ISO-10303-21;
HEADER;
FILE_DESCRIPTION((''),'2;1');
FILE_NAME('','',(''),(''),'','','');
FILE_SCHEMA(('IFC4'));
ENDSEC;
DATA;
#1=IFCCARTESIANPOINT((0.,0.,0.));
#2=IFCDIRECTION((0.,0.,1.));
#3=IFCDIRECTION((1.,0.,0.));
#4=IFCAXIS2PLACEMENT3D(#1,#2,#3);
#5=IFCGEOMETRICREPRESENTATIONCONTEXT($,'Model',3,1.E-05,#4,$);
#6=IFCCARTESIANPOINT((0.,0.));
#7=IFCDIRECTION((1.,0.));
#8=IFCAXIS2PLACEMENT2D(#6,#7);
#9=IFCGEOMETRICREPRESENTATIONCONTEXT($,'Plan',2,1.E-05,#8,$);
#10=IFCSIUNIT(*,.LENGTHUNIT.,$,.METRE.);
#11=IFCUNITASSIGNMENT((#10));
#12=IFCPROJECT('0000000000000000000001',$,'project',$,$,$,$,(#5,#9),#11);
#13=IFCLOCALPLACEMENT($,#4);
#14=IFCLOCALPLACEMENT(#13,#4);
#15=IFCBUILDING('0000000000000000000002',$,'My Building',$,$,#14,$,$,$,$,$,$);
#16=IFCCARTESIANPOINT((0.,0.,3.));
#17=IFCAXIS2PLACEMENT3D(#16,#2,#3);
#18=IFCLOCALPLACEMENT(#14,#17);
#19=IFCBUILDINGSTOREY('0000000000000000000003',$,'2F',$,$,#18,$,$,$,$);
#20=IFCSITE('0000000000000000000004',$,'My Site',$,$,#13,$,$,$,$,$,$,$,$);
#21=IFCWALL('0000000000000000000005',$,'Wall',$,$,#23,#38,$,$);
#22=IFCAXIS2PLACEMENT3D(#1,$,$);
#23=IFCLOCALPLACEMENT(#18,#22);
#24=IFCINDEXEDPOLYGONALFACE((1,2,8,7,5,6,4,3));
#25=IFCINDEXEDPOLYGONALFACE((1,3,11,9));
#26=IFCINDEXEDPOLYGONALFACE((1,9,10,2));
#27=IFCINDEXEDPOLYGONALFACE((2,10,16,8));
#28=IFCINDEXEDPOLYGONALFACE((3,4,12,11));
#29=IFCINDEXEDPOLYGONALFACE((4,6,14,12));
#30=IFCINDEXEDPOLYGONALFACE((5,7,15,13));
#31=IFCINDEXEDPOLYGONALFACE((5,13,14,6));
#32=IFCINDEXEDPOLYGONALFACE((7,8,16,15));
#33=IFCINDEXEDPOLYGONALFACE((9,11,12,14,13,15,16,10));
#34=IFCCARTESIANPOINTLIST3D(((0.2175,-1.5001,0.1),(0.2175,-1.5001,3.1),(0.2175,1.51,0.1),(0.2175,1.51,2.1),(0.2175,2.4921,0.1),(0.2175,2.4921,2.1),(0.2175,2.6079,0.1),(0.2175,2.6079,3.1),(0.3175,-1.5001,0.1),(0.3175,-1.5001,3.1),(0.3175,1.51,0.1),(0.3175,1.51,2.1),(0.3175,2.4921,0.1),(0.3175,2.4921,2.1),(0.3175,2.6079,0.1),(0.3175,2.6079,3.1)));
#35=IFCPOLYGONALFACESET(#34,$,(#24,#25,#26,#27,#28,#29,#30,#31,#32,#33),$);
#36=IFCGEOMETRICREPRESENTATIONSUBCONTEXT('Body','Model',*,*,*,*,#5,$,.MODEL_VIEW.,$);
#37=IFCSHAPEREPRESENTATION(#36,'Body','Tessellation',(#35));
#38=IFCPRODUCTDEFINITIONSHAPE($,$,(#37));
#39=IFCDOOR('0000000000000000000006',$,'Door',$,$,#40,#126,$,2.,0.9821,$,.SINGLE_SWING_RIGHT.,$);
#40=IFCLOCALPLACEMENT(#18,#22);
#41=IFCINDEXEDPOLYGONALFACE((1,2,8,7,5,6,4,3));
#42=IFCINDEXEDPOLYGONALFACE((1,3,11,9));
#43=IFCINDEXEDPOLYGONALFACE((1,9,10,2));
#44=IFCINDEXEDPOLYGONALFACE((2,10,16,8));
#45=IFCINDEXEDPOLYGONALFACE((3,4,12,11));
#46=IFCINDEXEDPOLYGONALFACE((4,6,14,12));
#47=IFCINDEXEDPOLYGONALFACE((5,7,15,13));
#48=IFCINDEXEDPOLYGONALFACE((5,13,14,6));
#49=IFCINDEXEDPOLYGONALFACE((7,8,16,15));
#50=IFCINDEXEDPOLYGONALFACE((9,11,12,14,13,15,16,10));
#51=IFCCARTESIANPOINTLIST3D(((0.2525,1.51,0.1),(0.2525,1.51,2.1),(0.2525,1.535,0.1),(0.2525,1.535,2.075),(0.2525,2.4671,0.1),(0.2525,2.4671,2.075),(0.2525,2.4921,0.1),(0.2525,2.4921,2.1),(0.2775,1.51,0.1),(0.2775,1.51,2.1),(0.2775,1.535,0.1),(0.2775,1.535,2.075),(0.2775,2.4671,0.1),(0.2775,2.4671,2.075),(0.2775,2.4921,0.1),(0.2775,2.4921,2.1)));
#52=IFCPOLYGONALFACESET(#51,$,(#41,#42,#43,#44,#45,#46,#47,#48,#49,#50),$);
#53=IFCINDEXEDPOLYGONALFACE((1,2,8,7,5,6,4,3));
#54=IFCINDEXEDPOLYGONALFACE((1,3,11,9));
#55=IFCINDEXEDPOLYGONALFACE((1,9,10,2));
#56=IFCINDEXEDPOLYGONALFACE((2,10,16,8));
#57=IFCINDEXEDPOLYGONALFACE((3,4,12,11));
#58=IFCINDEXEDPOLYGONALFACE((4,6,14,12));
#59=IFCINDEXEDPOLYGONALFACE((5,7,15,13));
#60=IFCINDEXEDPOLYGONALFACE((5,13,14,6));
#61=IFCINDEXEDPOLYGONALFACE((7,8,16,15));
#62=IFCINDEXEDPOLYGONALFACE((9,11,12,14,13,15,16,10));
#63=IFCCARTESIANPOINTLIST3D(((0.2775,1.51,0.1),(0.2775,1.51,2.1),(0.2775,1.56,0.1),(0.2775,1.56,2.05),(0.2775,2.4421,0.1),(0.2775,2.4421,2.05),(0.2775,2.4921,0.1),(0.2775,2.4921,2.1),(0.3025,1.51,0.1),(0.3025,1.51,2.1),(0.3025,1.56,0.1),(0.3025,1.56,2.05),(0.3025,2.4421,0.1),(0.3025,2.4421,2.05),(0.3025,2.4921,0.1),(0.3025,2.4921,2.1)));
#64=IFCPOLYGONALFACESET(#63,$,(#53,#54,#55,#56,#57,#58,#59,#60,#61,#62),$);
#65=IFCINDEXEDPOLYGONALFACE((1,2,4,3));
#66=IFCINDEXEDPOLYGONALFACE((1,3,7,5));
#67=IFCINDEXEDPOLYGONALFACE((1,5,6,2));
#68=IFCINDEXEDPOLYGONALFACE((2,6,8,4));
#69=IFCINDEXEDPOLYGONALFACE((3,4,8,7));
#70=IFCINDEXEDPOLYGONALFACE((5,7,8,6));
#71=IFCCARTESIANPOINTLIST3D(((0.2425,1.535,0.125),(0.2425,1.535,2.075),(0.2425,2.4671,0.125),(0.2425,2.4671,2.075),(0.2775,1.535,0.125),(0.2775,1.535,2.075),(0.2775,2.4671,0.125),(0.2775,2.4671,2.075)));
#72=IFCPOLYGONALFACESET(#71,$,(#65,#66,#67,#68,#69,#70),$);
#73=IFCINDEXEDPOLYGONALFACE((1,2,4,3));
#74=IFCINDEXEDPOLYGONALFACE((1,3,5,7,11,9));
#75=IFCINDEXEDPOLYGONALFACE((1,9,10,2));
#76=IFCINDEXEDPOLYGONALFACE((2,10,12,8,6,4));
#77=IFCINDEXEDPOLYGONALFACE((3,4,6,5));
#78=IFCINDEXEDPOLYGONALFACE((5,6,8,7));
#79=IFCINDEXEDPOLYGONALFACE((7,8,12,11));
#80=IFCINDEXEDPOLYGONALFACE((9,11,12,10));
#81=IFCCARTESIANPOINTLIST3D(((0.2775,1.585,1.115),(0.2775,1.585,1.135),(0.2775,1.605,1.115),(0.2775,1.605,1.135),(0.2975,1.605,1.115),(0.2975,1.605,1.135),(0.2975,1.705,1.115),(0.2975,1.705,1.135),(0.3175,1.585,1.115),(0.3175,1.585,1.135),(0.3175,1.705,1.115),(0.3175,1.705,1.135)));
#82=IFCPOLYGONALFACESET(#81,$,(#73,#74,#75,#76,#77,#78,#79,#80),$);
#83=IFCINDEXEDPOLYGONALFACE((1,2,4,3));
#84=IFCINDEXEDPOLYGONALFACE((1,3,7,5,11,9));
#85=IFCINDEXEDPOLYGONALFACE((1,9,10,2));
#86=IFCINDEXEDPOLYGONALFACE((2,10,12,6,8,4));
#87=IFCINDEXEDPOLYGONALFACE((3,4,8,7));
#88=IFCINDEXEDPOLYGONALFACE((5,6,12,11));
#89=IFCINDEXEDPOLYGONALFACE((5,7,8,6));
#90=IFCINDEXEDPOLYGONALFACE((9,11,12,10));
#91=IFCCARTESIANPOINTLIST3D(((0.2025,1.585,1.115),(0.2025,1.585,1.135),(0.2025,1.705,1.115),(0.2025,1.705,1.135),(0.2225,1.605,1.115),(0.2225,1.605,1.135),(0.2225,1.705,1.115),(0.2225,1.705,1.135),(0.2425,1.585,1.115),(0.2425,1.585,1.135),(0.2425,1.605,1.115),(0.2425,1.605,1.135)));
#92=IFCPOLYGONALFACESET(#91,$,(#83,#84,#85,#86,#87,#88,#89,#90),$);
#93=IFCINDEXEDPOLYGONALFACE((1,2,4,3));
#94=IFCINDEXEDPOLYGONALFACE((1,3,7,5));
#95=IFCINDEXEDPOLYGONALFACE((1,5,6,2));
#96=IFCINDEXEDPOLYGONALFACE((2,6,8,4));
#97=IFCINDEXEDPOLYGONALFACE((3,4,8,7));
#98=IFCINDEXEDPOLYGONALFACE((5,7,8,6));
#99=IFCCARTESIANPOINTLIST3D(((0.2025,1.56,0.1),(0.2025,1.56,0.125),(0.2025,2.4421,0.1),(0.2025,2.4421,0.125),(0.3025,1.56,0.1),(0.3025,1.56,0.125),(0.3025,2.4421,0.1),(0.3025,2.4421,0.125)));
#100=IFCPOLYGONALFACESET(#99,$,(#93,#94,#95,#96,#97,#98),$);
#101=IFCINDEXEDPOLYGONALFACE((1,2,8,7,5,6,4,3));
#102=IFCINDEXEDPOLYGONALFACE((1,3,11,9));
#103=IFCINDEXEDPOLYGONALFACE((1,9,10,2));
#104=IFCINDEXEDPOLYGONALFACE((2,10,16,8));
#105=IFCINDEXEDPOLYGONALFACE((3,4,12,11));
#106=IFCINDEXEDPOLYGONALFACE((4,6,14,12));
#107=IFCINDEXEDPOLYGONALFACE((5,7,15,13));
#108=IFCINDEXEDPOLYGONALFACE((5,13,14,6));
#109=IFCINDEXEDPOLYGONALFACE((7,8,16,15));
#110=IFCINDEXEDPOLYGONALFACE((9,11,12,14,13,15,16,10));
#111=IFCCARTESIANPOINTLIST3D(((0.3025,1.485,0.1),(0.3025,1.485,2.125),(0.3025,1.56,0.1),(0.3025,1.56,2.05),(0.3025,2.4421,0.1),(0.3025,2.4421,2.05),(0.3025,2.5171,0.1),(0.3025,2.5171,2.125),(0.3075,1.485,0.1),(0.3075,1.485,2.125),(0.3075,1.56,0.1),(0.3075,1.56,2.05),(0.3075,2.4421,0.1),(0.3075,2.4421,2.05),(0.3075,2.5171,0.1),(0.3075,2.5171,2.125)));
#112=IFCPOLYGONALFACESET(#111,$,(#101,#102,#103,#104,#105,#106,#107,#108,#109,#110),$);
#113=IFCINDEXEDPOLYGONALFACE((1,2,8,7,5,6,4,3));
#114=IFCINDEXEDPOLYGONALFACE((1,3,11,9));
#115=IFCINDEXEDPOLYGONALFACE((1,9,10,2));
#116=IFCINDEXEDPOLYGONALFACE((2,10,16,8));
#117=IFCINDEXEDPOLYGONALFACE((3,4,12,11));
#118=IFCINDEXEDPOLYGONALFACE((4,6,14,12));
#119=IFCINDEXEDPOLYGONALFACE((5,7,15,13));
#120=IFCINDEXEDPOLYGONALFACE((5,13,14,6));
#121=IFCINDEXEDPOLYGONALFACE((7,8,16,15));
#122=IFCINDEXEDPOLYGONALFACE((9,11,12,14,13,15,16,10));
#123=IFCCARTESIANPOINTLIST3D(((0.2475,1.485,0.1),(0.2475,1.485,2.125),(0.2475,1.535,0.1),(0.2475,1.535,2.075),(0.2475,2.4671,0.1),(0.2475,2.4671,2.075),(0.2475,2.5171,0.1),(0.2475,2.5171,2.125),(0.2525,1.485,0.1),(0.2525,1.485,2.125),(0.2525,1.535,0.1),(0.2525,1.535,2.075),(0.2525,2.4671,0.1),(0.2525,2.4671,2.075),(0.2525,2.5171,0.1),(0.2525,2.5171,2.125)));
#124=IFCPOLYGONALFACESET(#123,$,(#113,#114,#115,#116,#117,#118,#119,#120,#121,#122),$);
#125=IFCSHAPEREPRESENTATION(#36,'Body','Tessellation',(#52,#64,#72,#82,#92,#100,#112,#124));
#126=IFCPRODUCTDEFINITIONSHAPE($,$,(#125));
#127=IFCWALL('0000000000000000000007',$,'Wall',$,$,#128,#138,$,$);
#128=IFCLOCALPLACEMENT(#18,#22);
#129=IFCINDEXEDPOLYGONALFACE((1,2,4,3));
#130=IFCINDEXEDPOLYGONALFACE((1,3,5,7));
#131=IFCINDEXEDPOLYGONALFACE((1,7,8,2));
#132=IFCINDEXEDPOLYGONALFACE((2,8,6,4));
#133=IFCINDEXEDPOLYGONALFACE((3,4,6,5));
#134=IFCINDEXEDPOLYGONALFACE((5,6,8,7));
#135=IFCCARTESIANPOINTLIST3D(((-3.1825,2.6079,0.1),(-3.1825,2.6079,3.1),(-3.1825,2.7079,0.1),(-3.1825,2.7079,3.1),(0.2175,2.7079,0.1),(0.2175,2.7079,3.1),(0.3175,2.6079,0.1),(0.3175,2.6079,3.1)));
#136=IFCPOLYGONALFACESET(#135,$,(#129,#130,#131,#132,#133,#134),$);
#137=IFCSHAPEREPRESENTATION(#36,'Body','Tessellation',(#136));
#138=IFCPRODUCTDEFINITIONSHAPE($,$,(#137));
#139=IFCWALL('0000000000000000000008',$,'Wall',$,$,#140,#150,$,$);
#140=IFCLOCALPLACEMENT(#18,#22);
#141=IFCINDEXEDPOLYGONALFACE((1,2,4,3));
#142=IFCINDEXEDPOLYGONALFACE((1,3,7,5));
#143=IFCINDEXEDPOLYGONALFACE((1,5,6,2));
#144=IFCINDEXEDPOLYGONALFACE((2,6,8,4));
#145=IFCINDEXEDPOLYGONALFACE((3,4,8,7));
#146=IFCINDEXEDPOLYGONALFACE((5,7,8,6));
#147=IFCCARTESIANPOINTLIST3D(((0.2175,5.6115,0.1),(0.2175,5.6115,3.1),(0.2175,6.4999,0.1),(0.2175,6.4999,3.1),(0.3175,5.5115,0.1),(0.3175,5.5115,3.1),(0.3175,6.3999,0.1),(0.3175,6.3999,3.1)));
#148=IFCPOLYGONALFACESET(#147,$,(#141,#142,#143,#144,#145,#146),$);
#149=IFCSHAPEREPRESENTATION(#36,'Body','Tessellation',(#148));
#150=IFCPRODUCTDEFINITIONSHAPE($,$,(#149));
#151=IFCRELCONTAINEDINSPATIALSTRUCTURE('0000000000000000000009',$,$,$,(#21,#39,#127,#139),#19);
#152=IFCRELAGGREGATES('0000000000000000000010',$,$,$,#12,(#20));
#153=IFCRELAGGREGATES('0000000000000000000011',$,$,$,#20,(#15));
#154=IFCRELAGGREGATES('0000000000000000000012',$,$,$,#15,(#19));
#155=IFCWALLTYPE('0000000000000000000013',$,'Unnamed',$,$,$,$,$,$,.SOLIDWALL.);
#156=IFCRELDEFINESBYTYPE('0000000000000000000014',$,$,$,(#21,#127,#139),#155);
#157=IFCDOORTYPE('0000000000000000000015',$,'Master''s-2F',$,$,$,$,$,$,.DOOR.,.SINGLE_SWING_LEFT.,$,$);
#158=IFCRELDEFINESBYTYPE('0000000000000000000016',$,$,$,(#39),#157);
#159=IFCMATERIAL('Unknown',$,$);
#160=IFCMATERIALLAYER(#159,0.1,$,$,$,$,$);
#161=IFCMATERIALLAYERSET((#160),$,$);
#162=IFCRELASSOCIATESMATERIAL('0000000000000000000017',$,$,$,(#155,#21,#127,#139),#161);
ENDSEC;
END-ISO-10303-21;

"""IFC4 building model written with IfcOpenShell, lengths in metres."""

from ifc_helpers import new_model, entity, si_unit, frame, origin_with_axes, origin_2d_with_axis, place, context, subcontext, project, spatial, line, indexed_curve, outline, extrude, shape, source, transform, mapped, material, layer, layer_set, layer_usage, type_object, type_shapes, element, fill, save


model = new_model("IFC4")

# Units and contexts
model_context = context("Model", 3, precision=1e-05, world=origin_with_axes())
plan_context = context("Plan", 2, precision=1e-05, world=origin_2d_with_axis())
body_context_1 = subcontext(model_context, "Body", "Model", "MODEL_VIEW")
body_context_2 = subcontext(plan_context, "Body", "Plan", "PLAN_VIEW")
ifc_project = project(units=[si_unit("LENGTHUNIT", "METRE")], contexts=[model_context, plan_context])

# Site, building, storey
site_placement = place(None, origin_with_axes())
site = spatial("IfcSite", under=ifc_project, at=site_placement, Name="My Site")
building_placement = place(site_placement, origin_with_axes())
building = spatial("IfcBuilding", under=site, at=building_placement, Name="My Building")
storey_placement = place(building_placement, frame((0.0, 0.0, 3.0), z_axis=(0.0, 0.0, 1.0), x_axis=(1.0, 0.0, 0.0)))
storey = spatial("IfcBuildingStorey", under=building, at=storey_placement, Name="2F")

# Shared definitions
ifc_material = material(Name="Unknown")
ifc_layer = layer(ifc_material, 0.1)
ifc_layer_set = layer_set([ifc_layer])
wall_type = type_object("IfcWallType", Name="Unnamed", PredefinedType="SOLIDWALL", material=ifc_layer_set)

# Wall, opening, door
ifc_layer_usage_1 = layer_usage(ifc_layer_set, "AXIS2", "POSITIVE", 0.0)
wall_1_placement = place(storey_placement, frame((0.2175, 2.7079, 0.1), z_axis=(0.0, 0.0, 1.0), x_axis=(0.0, -1.0, 0.0)))
wall_1 = element("IfcWall", 1, at=wall_1_placement, inside=storey, type_object=wall_type, material=ifc_layer_usage_1, Name="Wall", context=body_context_1, shape_type="SweptSolid", body=[
    extrude(outline(indexed_curve([(0.1, 0.0), (0.1, 0.1), (4.2079, 0.1), (4.2079, 0.0)], segments=[line(1, 2, 3, 4, 1)])), origin_with_axes(), (0.0, 0.0, 1.0), 3.0),
])
shared_shape_1 = source(origin_with_axes(), body_context_1, "Body", "SweptSolid", [
    extrude(outline(indexed_curve([(0.0, 0.0), (0.9821, 0.0), (0.9821, 2.0), (0.0, 2.0)], segments=[line(1, 2, 3, 4, 1)])), frame((0.0, -0.6, 0.0), z_axis=(0.0, -1.0, 0.0), x_axis=(1.0, 0.0, 0.0)), (0.0, 0.0, -1.0), 1.2),
])
opening_1_placement = place(wall_1_placement, frame((1.1978, 0.085, 0.0), z_axis=(0.0, 0.0, 1.0), x_axis=(-1.0, 0.0, 0.0)))
opening_1 = element("IfcOpeningElement", 2, at=opening_1_placement, cuts=wall_1, PredefinedType="OPENING", context=body_context_1, shape_type="MappedRepresentation", body=[
    mapped(shared_shape_1, transform((0.0, 0.0, 0.0), x_axis=(1.0, 0.0, 0.0), y_axis=(0.0, 1.0, 0.0), z_axis=(0.0, 0.0, 1.0), scale=1.0)),
])
door_type_1 = type_object("IfcDoorType", Name="Master's-2F", OperationType="SINGLE_SWING_LEFT", PredefinedType="DOOR")
shared_shape_2 = source(origin_with_axes(), body_context_1, "Body", "SweptSolid", [
    extrude(outline(indexed_curve([(0.0, 0.0), (0.0, 2.0), (0.9821, 2.0), (0.9821, 0.0), (0.9571, 0.0), (0.9571, 1.975), (0.025, 1.975), (0.025, 0.0)], segments=[line(1, 2, 3, 4, 5, 6, 7, 8, 1)])), frame((0.0, 0.025, 0.0), z_axis=(0.0, -1.0, 0.0), x_axis=(1.0, 0.0, 0.0)), (0.0, 0.0, -1.0), 0.025),
    extrude(outline(indexed_curve([(0.0, 0.0), (0.0, 2.0), (0.9821, 2.0), (0.9821, 0.0), (0.9321, 0.0), (0.9321, 1.95), (0.05, 1.95), (0.05, 0.0)], segments=[line(1, 2, 3, 4, 5, 6, 7, 8, 1)])), frame((0.0, 0.0, 0.0), z_axis=(0.0, -1.0, 0.0), x_axis=(1.0, 0.0, 0.0)), (0.0, 0.0, -1.0), 0.025),
    extrude(outline(indexed_curve([(0.0, 0.0), (0.9321, 0.0), (0.9321, 0.035), (0.0, 0.035)], segments=[line(1, 2, 3, 4, 1)])), frame((0.025, 0.025, 0.025), z_axis=(0.0, 0.0, 1.0), x_axis=(1.0, 0.0, 0.0)), (0.0, 0.0, 1.0), 1.95),
    extrude(outline(indexed_curve([(0.0, 0.0), (0.0, -0.04), (0.12, -0.04), (0.12, -0.02), (0.02, -0.02), (0.02, 0.0)], segments=[line(1, 2, 3, 4, 5, 6, 1)])), frame((0.075, 0.025, 1.015), z_axis=(0.0, 0.0, 1.0), x_axis=(1.0, 0.0, 0.0)), (0.0, 0.0, 1.0), 0.02),
    extrude(outline(indexed_curve([(0.0, 0.0), (0.0, 0.04), (0.12, 0.04), (0.12, 0.02), (0.02, 0.02), (0.02, 0.0)], segments=[line(1, 2, 3, 4, 5, 6, 1)])), frame((0.075, 0.06, 1.015), z_axis=(0.0, 0.0, 1.0), x_axis=(1.0, 0.0, 0.0)), (0.0, 0.0, 1.0), 0.02),
    extrude(outline(indexed_curve([(0.0, 0.0), (0.8821, 0.0), (0.8821, 0.1), (0.0, 0.1)], segments=[line(1, 2, 3, 4, 1)])), frame((0.05, 0.0, 0.0), z_axis=(0.0, 0.0, 1.0), x_axis=(1.0, 0.0, 0.0)), (0.0, 0.0, 1.0), 0.025),
    extrude(outline(indexed_curve([(0.0, 0.0), (0.0, 2.025), (1.0321, 2.025), (1.0321, 0.0), (0.9571, 0.0), (0.9571, 1.95), (0.075, 1.95), (0.075, 0.0)], segments=[line(1, 2, 3, 4, 5, 6, 7, 8, 1)])), frame((-0.025, -0.005, 0.0), z_axis=(0.0, -1.0, 0.0), x_axis=(1.0, 0.0, 0.0)), (0.0, 0.0, -1.0), 0.005),
    extrude(outline(indexed_curve([(0.0, 0.0), (0.0, 2.025), (1.0321, 2.025), (1.0321, 0.0), (0.9821, 0.0), (0.9821, 1.975), (0.05, 1.975), (0.05, 0.0)], segments=[line(1, 2, 3, 4, 5, 6, 7, 8, 1)])), frame((-0.025, 0.05, 0.0), z_axis=(0.0, -1.0, 0.0), x_axis=(1.0, 0.0, 0.0)), (0.0, 0.0, -1.0), 0.005),
])
shared_shape_3 = source(origin_with_axes(), body_context_2, "Body", "Curve2D", [
    entity("IfcIndexedPolyCurve", entity("IfcCartesianPointList2D", [[0.0, 0.0], [0.0, 0.05], [0.025, 0.05], [0.025, 0.025], [0.05, 0.025], [0.05, 0.0]]), [entity("IfcLineIndex", [1, 2, 3, 4, 5, 6, 1])]),
    entity("IfcIndexedPolyCurve", entity("IfcCartesianPointList2D", [[0.9821, 0.0], [0.9821, 0.05], [0.9571, 0.05], [0.9571, 0.025], [0.9321, 0.025], [0.9321, 0.0]]), [entity("IfcLineIndex", [1, 2, 3, 4, 5, 6, 1])]),
    entity("IfcTrimmedCurve", entity("IfcEllipse", entity("IfcAxis2Placement2D", entity("IfcCartesianPoint", [0.9221, 0.05]), entity("IfcDirection", [1.0, 0.0])), 0.8971, 0.9321), [entity("IfcCartesianPoint", [0.9221, 0.9821])], [entity("IfcCartesianPoint", [0.025, 0.05])], True, "CARTESIAN"),
    entity("IfcIndexedPolyCurve", entity("IfcCartesianPointList2D", [[0.9571, 0.05], [0.9221, 0.05], [0.9221, 0.9821], [0.9571, 0.9821]]), [entity("IfcLineIndex", [1, 2, 3, 4, 1])]),
])
type_shapes(door_type_1, [shared_shape_2, shared_shape_3])
door_1_placement = place(opening_1_placement, frame((0.0, 0.0, 0.0), z_axis=(0.0, 0.0, 1.0), x_axis=(1.0, 0.0, 0.0)))
door_1 = element("IfcDoor", 3, at=door_1_placement, inside=storey, type_object=door_type_1, Name="Door", OperationType="SINGLE_SWING_RIGHT", OverallHeight=2.0, OverallWidth=0.9821, shapes=[
    shape(body_context_1, "Body", "MappedRepresentation", [mapped(shared_shape_2, transform((0.0, 0.0, 0.0), x_axis=(1.0, 0.0, 0.0), y_axis=(0.0, 1.0, 0.0), z_axis=(0.0, 0.0, 1.0), scale=1.0))]),
    shape(body_context_2, "Body", "MappedRepresentation", [mapped(shared_shape_3, transform((0.0, 0.0, 0.0), x_axis=(1.0, 0.0, 0.0), y_axis=(0.0, 1.0, 0.0), z_axis=(0.0, 0.0, 1.0), scale=1.0))]),
])
fill(opening_1, door_1)

# Walls
ifc_layer_usage_2 = layer_usage(ifc_layer_set, "AXIS2", "POSITIVE", 0.0)
wall_2_placement = place(storey_placement, frame((0.3175, 2.7079, 0.1), z_axis=(0.0, 0.0, 1.0), x_axis=(-1.0, 0.0, 0.0)))
element("IfcWall", 4, at=wall_2_placement, inside=storey, type_object=wall_type, material=ifc_layer_usage_2, Name="Wall", context=body_context_1, shape_type="SweptSolid", body=[
    extrude(outline(indexed_curve([(0.1, 0.0), (0.0, 0.1), (3.5, 0.1), (3.5, 0.0)], segments=[line(1, 2, 3, 4, 1)])), origin_with_axes(), (0.0, 0.0, 1.0), 3.0),
])
ifc_layer_usage_3 = layer_usage(ifc_layer_set, "AXIS2", "POSITIVE", 0.0)
wall_3_placement = place(storey_placement, frame((0.3175, 5.5115, 0.1), z_axis=(0.0, 0.0, 1.0), x_axis=(0.0, 1.0, 0.0)))
element("IfcWall", 5, at=wall_3_placement, inside=storey, type_object=wall_type, material=ifc_layer_usage_3, Name="Wall", context=body_context_1, shape_type="SweptSolid", body=[
    extrude(outline(indexed_curve([(0.0, 0.0), (0.1, 0.1), (0.9884, 0.1), (0.8884, 0.0)], segments=[line(1, 2, 3, 4, 1)])), origin_with_axes(), (0.0, 0.0, 1.0), 3.0),
])

save(model, "model.ifc")
